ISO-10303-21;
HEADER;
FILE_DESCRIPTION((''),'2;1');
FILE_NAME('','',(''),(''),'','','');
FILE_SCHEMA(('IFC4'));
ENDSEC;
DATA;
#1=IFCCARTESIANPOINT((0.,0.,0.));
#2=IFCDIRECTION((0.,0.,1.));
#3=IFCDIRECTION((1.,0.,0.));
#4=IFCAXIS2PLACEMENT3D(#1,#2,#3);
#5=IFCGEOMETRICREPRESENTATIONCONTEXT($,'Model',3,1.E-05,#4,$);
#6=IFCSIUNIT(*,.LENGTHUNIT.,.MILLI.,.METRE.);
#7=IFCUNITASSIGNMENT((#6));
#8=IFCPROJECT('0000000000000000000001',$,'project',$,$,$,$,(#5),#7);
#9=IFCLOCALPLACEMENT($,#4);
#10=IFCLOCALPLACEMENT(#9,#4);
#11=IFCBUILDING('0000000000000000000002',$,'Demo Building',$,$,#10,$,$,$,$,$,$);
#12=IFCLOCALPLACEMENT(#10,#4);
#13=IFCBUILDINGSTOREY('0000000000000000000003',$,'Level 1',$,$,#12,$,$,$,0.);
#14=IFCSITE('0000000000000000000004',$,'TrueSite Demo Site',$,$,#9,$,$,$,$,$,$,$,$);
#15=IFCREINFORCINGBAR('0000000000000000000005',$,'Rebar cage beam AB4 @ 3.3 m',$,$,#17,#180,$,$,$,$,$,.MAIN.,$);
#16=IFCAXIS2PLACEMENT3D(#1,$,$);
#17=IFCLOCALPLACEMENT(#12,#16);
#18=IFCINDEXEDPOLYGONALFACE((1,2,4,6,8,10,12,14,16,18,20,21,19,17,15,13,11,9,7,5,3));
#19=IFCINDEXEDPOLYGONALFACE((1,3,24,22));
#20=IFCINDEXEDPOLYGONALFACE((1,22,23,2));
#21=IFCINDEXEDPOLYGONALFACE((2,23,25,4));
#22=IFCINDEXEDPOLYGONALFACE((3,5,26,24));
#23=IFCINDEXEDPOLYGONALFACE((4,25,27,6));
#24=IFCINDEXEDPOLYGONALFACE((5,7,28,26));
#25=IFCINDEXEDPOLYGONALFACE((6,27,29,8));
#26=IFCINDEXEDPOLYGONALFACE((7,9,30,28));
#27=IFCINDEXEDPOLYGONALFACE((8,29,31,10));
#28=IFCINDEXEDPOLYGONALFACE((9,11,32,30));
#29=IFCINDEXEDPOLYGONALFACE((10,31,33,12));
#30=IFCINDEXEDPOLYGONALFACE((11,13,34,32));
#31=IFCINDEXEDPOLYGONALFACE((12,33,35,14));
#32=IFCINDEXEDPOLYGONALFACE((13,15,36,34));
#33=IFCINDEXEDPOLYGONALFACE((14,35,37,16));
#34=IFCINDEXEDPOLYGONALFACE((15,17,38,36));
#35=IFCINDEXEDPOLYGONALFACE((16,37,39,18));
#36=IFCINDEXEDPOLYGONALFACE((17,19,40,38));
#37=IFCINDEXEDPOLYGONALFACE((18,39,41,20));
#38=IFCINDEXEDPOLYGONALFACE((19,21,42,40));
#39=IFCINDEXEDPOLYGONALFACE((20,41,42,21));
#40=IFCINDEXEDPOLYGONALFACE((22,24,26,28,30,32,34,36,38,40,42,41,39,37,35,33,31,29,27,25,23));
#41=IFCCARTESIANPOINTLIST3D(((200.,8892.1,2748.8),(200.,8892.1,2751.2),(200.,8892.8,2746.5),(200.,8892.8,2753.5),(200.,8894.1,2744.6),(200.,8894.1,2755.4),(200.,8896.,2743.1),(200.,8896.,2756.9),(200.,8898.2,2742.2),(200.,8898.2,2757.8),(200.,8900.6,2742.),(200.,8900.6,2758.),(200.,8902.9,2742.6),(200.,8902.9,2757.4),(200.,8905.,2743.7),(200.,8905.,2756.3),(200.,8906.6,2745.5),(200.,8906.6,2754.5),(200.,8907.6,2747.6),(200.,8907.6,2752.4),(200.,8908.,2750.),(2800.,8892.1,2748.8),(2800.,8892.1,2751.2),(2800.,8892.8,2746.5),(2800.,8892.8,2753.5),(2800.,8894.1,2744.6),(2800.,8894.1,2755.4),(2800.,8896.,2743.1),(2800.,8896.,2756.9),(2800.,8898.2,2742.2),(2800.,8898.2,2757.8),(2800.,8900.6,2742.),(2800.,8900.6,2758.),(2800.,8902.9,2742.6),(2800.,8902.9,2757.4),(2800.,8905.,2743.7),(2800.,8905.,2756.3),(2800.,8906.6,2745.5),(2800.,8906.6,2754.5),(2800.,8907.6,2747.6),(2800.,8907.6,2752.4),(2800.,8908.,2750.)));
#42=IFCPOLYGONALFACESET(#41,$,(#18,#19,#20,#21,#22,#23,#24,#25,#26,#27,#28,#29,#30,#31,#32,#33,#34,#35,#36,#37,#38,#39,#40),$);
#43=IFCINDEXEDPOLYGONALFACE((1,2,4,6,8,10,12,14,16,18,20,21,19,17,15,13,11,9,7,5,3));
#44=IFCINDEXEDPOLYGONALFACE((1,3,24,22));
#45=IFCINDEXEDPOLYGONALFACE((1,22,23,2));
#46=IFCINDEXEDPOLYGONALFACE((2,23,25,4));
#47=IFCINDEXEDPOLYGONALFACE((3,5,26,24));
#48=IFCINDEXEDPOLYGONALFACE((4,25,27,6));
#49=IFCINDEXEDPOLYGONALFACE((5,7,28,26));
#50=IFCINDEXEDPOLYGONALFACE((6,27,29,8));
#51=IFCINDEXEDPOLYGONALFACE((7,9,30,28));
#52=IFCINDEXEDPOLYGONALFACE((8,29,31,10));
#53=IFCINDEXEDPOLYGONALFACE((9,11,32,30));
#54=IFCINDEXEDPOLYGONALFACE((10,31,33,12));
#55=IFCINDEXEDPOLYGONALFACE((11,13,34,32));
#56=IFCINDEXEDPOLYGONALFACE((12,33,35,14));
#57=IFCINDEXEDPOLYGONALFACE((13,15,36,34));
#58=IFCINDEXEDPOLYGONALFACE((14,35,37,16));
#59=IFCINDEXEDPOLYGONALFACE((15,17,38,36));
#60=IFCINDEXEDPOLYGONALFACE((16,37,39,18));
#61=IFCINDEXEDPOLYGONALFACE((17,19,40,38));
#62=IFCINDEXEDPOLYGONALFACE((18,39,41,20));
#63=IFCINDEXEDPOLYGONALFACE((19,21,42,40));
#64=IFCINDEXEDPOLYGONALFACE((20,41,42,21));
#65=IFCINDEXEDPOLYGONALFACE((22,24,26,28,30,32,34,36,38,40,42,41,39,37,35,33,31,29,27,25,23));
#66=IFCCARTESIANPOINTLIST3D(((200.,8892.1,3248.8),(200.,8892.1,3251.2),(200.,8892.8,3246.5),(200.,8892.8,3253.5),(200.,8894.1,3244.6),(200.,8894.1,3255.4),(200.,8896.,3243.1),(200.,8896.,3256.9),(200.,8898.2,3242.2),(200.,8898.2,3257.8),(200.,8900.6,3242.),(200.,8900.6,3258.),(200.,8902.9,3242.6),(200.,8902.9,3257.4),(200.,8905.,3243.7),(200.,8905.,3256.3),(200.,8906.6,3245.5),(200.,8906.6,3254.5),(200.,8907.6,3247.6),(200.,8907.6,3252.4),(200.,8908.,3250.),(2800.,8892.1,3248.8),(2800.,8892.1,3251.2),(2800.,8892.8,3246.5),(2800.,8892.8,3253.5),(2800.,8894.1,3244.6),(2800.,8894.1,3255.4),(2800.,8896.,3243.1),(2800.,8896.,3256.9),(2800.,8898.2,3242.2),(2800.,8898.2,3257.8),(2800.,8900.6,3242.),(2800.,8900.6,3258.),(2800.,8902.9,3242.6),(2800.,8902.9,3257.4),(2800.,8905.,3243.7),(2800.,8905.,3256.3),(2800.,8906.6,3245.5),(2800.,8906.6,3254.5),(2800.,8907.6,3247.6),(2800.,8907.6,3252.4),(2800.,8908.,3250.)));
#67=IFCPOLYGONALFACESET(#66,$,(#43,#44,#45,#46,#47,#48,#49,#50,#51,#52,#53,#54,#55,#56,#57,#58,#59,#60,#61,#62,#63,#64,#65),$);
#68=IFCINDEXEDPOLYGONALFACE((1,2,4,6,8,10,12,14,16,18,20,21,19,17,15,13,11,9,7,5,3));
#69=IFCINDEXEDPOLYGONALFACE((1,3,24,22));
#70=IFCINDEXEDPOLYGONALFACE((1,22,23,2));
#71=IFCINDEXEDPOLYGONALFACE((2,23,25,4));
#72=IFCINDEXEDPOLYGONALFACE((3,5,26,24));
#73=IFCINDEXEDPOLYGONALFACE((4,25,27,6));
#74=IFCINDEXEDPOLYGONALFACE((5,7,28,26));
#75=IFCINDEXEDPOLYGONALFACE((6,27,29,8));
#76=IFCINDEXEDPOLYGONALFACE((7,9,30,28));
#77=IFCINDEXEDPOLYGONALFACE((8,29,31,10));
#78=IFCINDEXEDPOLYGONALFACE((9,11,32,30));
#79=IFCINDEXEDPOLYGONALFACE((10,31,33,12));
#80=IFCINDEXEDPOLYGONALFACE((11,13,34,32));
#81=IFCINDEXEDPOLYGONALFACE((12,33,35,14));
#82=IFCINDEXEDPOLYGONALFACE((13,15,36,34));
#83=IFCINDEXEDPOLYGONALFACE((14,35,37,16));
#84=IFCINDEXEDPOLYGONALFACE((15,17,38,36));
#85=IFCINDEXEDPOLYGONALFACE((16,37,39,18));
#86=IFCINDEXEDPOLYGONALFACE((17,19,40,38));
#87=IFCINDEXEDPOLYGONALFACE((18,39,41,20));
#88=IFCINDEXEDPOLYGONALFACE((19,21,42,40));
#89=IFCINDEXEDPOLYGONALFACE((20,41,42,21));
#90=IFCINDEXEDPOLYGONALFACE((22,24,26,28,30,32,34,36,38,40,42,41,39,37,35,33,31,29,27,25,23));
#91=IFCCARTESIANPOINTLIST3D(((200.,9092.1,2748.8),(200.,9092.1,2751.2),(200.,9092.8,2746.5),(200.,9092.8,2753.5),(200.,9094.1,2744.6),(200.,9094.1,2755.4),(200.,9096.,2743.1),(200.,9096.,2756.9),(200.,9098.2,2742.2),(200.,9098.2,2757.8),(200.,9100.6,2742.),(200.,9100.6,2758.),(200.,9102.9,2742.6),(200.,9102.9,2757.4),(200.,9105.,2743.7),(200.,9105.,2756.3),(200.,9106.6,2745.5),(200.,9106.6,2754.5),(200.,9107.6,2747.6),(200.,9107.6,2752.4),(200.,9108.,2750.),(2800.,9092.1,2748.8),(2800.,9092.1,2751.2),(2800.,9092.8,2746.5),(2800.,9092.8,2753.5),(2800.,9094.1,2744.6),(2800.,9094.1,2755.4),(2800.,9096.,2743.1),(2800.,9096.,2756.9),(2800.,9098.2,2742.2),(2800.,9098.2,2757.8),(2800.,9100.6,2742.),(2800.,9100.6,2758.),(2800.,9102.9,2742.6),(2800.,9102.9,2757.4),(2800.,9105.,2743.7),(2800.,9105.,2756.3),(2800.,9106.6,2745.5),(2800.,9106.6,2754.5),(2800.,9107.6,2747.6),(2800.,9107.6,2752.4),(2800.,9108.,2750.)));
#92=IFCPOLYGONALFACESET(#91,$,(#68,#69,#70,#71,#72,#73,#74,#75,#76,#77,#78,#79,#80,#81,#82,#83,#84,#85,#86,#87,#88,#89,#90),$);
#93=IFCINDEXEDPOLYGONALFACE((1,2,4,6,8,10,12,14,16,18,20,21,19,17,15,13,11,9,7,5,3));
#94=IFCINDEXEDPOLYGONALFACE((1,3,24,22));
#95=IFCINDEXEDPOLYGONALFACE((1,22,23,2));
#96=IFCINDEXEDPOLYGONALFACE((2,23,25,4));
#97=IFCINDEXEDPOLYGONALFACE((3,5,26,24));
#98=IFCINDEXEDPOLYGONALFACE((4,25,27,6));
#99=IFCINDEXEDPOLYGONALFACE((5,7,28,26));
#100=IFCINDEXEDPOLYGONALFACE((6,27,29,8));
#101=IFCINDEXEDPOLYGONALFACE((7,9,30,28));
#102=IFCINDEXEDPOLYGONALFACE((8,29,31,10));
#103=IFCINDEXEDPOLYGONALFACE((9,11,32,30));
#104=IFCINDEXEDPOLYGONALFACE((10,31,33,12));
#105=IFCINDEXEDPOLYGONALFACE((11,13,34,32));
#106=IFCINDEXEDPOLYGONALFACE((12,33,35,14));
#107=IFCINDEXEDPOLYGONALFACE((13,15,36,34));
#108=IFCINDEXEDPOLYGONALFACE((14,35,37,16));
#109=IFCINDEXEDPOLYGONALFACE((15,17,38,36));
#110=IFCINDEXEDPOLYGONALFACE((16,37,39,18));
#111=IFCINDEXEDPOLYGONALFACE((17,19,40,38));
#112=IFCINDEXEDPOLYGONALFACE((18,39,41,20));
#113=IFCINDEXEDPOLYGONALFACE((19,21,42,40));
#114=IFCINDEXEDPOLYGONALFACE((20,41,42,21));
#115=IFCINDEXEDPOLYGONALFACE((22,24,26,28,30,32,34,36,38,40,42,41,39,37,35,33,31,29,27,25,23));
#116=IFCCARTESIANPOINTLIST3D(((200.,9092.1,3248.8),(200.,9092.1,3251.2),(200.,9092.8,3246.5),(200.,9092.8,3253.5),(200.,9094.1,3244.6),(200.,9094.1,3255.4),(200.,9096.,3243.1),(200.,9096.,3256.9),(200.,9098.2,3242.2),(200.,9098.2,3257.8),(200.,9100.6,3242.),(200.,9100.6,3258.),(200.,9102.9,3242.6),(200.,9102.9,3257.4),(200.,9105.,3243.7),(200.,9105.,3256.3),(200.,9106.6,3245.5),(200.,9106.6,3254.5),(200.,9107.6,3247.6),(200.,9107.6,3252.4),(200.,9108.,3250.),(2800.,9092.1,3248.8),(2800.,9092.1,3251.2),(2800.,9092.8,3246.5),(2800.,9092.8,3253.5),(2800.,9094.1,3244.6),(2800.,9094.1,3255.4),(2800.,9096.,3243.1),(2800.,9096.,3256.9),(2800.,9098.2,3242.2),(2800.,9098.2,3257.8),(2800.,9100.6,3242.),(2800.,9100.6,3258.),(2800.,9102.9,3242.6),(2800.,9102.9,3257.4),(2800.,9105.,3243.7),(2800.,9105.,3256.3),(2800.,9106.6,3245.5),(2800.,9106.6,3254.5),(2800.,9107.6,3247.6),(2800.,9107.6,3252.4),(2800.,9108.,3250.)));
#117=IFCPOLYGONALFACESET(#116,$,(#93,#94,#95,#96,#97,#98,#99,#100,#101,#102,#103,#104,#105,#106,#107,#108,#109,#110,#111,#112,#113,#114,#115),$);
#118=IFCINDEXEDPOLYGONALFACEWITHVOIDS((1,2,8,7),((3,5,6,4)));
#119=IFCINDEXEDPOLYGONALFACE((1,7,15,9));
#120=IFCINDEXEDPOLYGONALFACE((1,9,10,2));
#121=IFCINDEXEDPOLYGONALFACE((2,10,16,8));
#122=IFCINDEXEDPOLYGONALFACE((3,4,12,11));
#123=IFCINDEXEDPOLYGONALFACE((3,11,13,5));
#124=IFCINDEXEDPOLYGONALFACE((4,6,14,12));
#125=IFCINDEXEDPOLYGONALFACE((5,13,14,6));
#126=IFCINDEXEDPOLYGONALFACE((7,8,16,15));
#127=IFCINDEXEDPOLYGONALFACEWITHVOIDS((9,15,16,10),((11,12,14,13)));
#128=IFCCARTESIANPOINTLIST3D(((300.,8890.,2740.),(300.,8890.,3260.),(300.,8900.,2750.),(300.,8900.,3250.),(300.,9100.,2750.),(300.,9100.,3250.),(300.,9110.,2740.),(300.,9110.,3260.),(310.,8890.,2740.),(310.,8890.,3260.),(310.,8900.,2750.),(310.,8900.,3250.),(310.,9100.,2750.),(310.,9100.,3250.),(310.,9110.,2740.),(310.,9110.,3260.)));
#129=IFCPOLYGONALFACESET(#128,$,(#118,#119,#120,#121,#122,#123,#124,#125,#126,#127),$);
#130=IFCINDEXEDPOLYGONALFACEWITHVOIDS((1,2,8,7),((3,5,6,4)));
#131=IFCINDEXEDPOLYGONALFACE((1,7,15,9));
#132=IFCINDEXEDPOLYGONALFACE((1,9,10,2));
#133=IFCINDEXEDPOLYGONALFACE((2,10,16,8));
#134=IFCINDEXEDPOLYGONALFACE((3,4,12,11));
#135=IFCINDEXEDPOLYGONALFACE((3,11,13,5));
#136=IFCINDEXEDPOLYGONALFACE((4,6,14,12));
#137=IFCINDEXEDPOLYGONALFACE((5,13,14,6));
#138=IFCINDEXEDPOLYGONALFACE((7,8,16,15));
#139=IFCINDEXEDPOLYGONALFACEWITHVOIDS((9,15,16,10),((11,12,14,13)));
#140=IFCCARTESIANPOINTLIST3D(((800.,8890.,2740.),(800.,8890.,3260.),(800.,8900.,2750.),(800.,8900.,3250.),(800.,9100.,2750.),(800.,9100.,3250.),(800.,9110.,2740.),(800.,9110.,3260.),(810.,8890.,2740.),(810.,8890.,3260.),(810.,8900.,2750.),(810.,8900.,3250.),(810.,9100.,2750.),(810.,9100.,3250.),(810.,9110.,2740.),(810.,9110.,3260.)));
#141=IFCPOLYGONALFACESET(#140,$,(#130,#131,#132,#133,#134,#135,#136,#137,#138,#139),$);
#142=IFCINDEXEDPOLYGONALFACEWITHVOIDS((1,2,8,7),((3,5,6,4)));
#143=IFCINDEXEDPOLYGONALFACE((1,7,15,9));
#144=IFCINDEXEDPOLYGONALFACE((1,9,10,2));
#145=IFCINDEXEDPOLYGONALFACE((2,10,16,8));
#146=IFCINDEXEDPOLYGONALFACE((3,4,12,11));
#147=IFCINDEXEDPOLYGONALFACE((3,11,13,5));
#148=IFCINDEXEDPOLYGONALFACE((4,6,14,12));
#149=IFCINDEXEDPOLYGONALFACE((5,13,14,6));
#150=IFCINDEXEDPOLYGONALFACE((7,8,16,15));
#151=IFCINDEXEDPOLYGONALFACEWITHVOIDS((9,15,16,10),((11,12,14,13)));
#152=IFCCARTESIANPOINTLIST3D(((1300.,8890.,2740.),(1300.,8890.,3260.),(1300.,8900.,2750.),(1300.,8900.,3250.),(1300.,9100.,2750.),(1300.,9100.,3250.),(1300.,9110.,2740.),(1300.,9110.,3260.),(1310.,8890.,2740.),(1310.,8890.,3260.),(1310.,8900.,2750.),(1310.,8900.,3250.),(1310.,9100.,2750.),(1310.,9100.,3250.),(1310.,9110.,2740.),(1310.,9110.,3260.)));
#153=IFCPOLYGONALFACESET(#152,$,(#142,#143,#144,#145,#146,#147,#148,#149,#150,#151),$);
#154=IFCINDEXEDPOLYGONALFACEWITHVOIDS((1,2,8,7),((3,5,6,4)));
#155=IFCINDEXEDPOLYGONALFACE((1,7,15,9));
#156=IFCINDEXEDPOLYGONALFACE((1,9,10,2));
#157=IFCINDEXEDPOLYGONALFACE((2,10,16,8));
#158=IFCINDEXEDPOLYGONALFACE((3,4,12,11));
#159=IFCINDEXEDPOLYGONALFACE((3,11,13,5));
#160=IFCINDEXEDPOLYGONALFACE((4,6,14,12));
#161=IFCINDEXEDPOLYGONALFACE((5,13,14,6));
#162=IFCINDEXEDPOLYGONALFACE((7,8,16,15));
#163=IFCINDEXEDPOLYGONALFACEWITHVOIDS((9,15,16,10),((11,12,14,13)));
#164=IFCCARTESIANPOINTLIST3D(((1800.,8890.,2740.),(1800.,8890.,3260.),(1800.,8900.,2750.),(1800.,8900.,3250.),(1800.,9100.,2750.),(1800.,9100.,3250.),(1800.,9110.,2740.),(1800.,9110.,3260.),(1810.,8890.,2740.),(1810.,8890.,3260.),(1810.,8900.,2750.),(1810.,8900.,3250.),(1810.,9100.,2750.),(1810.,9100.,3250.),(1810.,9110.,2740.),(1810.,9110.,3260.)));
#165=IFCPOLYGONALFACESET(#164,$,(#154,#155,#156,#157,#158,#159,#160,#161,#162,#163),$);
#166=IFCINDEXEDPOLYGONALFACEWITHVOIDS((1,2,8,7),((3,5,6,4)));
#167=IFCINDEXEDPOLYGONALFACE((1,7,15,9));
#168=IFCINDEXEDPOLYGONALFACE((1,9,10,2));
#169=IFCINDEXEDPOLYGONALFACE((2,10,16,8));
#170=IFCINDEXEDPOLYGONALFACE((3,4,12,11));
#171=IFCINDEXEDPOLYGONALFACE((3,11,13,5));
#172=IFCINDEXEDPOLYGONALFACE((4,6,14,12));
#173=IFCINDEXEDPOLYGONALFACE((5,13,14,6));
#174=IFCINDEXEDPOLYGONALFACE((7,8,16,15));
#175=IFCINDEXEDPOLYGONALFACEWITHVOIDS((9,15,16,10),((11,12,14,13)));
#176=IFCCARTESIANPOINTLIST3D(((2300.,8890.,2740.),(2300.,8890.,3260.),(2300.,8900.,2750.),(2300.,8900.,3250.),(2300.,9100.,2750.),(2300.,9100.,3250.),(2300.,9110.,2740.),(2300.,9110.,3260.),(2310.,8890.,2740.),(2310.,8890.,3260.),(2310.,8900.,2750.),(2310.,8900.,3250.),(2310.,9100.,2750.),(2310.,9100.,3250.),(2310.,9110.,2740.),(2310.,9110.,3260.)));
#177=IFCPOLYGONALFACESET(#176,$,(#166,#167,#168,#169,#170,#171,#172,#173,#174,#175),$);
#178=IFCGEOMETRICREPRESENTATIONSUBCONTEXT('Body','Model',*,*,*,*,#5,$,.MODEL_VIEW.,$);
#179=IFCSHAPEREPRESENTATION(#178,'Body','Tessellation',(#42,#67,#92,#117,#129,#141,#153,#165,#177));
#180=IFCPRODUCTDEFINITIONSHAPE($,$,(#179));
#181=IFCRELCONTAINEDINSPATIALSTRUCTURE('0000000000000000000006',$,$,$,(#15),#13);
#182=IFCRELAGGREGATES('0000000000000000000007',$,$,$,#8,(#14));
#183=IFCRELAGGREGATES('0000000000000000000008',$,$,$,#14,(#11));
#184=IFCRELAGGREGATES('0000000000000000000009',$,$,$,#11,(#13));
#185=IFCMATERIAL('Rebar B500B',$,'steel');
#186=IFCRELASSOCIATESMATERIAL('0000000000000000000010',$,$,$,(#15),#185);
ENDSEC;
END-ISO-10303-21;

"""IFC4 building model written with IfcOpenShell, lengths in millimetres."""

from ifc_helpers import new_model, si_unit, frame, origin_with_axes, place, context, subcontext, project, spatial, hollow_rectangle, circle, extrude, material, element, save


model = new_model("IFC4")

# Units and contexts
model_context = context("Model", 3, precision=1e-05, world=origin_with_axes())
body_context = subcontext(model_context, "Body", "Model", "MODEL_VIEW")
ifc_project = project(units=[si_unit("LENGTHUNIT", "METRE", prefix="MILLI")], contexts=[model_context])

# Site, building, storey
site_placement = place(None, origin_with_axes())
site = spatial("IfcSite", under=ifc_project, at=site_placement, Name="TrueSite Demo Site")
building_placement = place(site_placement, origin_with_axes())
building = spatial("IfcBuilding", under=site, at=building_placement, Name="Demo Building")
storey_placement = place(building_placement, origin_with_axes())
storey = spatial("IfcBuildingStorey", under=building, at=storey_placement, Name="Level 1", Elevation=0.0)

# Reinforcing bar
ifc_material_1 = material(Name="Rebar B500B", Category="steel")
for number, where, z_axis, x_axis, name in (
    (1, (200.0, 9000.0, 3000.0), (1.0, 0.0, 0.0), (0.0, 1.0, 0.0), "Rebar cage beam AB4 @ 3.3 m"),
):
    element("IfcReinforcingBar", number, at=place(storey_placement, frame(where, z_axis=z_axis, x_axis=x_axis)), inside=storey, material=ifc_material_1, Name=name, PredefinedType="MAIN", context=body_context, shape_type="SweptSolid", body=[
        extrude(circle(Radius=8.0), frame((-100.0, -250.0, 0.0)), (0.0, 0.0, 1.0), 2600.0),
        extrude(circle(Radius=8.0), frame((-100.0, 250.0, 0.0)), (0.0, 0.0, 1.0), 2600.0),
        extrude(circle(Radius=8.0), frame((100.0, -250.0, 0.0)), (0.0, 0.0, 1.0), 2600.0),
        extrude(circle(Radius=8.0), frame((100.0, 250.0, 0.0)), (0.0, 0.0, 1.0), 2600.0),
        extrude(hollow_rectangle(XDim=220.0, YDim=520.0, WallThickness=10.0), frame((0.0, 0.0, 100.0)), (0.0, 0.0, 1.0), 10.0),
        extrude(hollow_rectangle(XDim=220.0, YDim=520.0, WallThickness=10.0), frame((0.0, 0.0, 600.0)), (0.0, 0.0, 1.0), 10.0),
        extrude(hollow_rectangle(XDim=220.0, YDim=520.0, WallThickness=10.0), frame((0.0, 0.0, 1100.0)), (0.0, 0.0, 1.0), 10.0),
        extrude(hollow_rectangle(XDim=220.0, YDim=520.0, WallThickness=10.0), frame((0.0, 0.0, 1600.0)), (0.0, 0.0, 1.0), 10.0),
        extrude(hollow_rectangle(XDim=220.0, YDim=520.0, WallThickness=10.0), frame((0.0, 0.0, 2100.0)), (0.0, 0.0, 1.0), 10.0),
    ])

save(model, "model.ifc")
